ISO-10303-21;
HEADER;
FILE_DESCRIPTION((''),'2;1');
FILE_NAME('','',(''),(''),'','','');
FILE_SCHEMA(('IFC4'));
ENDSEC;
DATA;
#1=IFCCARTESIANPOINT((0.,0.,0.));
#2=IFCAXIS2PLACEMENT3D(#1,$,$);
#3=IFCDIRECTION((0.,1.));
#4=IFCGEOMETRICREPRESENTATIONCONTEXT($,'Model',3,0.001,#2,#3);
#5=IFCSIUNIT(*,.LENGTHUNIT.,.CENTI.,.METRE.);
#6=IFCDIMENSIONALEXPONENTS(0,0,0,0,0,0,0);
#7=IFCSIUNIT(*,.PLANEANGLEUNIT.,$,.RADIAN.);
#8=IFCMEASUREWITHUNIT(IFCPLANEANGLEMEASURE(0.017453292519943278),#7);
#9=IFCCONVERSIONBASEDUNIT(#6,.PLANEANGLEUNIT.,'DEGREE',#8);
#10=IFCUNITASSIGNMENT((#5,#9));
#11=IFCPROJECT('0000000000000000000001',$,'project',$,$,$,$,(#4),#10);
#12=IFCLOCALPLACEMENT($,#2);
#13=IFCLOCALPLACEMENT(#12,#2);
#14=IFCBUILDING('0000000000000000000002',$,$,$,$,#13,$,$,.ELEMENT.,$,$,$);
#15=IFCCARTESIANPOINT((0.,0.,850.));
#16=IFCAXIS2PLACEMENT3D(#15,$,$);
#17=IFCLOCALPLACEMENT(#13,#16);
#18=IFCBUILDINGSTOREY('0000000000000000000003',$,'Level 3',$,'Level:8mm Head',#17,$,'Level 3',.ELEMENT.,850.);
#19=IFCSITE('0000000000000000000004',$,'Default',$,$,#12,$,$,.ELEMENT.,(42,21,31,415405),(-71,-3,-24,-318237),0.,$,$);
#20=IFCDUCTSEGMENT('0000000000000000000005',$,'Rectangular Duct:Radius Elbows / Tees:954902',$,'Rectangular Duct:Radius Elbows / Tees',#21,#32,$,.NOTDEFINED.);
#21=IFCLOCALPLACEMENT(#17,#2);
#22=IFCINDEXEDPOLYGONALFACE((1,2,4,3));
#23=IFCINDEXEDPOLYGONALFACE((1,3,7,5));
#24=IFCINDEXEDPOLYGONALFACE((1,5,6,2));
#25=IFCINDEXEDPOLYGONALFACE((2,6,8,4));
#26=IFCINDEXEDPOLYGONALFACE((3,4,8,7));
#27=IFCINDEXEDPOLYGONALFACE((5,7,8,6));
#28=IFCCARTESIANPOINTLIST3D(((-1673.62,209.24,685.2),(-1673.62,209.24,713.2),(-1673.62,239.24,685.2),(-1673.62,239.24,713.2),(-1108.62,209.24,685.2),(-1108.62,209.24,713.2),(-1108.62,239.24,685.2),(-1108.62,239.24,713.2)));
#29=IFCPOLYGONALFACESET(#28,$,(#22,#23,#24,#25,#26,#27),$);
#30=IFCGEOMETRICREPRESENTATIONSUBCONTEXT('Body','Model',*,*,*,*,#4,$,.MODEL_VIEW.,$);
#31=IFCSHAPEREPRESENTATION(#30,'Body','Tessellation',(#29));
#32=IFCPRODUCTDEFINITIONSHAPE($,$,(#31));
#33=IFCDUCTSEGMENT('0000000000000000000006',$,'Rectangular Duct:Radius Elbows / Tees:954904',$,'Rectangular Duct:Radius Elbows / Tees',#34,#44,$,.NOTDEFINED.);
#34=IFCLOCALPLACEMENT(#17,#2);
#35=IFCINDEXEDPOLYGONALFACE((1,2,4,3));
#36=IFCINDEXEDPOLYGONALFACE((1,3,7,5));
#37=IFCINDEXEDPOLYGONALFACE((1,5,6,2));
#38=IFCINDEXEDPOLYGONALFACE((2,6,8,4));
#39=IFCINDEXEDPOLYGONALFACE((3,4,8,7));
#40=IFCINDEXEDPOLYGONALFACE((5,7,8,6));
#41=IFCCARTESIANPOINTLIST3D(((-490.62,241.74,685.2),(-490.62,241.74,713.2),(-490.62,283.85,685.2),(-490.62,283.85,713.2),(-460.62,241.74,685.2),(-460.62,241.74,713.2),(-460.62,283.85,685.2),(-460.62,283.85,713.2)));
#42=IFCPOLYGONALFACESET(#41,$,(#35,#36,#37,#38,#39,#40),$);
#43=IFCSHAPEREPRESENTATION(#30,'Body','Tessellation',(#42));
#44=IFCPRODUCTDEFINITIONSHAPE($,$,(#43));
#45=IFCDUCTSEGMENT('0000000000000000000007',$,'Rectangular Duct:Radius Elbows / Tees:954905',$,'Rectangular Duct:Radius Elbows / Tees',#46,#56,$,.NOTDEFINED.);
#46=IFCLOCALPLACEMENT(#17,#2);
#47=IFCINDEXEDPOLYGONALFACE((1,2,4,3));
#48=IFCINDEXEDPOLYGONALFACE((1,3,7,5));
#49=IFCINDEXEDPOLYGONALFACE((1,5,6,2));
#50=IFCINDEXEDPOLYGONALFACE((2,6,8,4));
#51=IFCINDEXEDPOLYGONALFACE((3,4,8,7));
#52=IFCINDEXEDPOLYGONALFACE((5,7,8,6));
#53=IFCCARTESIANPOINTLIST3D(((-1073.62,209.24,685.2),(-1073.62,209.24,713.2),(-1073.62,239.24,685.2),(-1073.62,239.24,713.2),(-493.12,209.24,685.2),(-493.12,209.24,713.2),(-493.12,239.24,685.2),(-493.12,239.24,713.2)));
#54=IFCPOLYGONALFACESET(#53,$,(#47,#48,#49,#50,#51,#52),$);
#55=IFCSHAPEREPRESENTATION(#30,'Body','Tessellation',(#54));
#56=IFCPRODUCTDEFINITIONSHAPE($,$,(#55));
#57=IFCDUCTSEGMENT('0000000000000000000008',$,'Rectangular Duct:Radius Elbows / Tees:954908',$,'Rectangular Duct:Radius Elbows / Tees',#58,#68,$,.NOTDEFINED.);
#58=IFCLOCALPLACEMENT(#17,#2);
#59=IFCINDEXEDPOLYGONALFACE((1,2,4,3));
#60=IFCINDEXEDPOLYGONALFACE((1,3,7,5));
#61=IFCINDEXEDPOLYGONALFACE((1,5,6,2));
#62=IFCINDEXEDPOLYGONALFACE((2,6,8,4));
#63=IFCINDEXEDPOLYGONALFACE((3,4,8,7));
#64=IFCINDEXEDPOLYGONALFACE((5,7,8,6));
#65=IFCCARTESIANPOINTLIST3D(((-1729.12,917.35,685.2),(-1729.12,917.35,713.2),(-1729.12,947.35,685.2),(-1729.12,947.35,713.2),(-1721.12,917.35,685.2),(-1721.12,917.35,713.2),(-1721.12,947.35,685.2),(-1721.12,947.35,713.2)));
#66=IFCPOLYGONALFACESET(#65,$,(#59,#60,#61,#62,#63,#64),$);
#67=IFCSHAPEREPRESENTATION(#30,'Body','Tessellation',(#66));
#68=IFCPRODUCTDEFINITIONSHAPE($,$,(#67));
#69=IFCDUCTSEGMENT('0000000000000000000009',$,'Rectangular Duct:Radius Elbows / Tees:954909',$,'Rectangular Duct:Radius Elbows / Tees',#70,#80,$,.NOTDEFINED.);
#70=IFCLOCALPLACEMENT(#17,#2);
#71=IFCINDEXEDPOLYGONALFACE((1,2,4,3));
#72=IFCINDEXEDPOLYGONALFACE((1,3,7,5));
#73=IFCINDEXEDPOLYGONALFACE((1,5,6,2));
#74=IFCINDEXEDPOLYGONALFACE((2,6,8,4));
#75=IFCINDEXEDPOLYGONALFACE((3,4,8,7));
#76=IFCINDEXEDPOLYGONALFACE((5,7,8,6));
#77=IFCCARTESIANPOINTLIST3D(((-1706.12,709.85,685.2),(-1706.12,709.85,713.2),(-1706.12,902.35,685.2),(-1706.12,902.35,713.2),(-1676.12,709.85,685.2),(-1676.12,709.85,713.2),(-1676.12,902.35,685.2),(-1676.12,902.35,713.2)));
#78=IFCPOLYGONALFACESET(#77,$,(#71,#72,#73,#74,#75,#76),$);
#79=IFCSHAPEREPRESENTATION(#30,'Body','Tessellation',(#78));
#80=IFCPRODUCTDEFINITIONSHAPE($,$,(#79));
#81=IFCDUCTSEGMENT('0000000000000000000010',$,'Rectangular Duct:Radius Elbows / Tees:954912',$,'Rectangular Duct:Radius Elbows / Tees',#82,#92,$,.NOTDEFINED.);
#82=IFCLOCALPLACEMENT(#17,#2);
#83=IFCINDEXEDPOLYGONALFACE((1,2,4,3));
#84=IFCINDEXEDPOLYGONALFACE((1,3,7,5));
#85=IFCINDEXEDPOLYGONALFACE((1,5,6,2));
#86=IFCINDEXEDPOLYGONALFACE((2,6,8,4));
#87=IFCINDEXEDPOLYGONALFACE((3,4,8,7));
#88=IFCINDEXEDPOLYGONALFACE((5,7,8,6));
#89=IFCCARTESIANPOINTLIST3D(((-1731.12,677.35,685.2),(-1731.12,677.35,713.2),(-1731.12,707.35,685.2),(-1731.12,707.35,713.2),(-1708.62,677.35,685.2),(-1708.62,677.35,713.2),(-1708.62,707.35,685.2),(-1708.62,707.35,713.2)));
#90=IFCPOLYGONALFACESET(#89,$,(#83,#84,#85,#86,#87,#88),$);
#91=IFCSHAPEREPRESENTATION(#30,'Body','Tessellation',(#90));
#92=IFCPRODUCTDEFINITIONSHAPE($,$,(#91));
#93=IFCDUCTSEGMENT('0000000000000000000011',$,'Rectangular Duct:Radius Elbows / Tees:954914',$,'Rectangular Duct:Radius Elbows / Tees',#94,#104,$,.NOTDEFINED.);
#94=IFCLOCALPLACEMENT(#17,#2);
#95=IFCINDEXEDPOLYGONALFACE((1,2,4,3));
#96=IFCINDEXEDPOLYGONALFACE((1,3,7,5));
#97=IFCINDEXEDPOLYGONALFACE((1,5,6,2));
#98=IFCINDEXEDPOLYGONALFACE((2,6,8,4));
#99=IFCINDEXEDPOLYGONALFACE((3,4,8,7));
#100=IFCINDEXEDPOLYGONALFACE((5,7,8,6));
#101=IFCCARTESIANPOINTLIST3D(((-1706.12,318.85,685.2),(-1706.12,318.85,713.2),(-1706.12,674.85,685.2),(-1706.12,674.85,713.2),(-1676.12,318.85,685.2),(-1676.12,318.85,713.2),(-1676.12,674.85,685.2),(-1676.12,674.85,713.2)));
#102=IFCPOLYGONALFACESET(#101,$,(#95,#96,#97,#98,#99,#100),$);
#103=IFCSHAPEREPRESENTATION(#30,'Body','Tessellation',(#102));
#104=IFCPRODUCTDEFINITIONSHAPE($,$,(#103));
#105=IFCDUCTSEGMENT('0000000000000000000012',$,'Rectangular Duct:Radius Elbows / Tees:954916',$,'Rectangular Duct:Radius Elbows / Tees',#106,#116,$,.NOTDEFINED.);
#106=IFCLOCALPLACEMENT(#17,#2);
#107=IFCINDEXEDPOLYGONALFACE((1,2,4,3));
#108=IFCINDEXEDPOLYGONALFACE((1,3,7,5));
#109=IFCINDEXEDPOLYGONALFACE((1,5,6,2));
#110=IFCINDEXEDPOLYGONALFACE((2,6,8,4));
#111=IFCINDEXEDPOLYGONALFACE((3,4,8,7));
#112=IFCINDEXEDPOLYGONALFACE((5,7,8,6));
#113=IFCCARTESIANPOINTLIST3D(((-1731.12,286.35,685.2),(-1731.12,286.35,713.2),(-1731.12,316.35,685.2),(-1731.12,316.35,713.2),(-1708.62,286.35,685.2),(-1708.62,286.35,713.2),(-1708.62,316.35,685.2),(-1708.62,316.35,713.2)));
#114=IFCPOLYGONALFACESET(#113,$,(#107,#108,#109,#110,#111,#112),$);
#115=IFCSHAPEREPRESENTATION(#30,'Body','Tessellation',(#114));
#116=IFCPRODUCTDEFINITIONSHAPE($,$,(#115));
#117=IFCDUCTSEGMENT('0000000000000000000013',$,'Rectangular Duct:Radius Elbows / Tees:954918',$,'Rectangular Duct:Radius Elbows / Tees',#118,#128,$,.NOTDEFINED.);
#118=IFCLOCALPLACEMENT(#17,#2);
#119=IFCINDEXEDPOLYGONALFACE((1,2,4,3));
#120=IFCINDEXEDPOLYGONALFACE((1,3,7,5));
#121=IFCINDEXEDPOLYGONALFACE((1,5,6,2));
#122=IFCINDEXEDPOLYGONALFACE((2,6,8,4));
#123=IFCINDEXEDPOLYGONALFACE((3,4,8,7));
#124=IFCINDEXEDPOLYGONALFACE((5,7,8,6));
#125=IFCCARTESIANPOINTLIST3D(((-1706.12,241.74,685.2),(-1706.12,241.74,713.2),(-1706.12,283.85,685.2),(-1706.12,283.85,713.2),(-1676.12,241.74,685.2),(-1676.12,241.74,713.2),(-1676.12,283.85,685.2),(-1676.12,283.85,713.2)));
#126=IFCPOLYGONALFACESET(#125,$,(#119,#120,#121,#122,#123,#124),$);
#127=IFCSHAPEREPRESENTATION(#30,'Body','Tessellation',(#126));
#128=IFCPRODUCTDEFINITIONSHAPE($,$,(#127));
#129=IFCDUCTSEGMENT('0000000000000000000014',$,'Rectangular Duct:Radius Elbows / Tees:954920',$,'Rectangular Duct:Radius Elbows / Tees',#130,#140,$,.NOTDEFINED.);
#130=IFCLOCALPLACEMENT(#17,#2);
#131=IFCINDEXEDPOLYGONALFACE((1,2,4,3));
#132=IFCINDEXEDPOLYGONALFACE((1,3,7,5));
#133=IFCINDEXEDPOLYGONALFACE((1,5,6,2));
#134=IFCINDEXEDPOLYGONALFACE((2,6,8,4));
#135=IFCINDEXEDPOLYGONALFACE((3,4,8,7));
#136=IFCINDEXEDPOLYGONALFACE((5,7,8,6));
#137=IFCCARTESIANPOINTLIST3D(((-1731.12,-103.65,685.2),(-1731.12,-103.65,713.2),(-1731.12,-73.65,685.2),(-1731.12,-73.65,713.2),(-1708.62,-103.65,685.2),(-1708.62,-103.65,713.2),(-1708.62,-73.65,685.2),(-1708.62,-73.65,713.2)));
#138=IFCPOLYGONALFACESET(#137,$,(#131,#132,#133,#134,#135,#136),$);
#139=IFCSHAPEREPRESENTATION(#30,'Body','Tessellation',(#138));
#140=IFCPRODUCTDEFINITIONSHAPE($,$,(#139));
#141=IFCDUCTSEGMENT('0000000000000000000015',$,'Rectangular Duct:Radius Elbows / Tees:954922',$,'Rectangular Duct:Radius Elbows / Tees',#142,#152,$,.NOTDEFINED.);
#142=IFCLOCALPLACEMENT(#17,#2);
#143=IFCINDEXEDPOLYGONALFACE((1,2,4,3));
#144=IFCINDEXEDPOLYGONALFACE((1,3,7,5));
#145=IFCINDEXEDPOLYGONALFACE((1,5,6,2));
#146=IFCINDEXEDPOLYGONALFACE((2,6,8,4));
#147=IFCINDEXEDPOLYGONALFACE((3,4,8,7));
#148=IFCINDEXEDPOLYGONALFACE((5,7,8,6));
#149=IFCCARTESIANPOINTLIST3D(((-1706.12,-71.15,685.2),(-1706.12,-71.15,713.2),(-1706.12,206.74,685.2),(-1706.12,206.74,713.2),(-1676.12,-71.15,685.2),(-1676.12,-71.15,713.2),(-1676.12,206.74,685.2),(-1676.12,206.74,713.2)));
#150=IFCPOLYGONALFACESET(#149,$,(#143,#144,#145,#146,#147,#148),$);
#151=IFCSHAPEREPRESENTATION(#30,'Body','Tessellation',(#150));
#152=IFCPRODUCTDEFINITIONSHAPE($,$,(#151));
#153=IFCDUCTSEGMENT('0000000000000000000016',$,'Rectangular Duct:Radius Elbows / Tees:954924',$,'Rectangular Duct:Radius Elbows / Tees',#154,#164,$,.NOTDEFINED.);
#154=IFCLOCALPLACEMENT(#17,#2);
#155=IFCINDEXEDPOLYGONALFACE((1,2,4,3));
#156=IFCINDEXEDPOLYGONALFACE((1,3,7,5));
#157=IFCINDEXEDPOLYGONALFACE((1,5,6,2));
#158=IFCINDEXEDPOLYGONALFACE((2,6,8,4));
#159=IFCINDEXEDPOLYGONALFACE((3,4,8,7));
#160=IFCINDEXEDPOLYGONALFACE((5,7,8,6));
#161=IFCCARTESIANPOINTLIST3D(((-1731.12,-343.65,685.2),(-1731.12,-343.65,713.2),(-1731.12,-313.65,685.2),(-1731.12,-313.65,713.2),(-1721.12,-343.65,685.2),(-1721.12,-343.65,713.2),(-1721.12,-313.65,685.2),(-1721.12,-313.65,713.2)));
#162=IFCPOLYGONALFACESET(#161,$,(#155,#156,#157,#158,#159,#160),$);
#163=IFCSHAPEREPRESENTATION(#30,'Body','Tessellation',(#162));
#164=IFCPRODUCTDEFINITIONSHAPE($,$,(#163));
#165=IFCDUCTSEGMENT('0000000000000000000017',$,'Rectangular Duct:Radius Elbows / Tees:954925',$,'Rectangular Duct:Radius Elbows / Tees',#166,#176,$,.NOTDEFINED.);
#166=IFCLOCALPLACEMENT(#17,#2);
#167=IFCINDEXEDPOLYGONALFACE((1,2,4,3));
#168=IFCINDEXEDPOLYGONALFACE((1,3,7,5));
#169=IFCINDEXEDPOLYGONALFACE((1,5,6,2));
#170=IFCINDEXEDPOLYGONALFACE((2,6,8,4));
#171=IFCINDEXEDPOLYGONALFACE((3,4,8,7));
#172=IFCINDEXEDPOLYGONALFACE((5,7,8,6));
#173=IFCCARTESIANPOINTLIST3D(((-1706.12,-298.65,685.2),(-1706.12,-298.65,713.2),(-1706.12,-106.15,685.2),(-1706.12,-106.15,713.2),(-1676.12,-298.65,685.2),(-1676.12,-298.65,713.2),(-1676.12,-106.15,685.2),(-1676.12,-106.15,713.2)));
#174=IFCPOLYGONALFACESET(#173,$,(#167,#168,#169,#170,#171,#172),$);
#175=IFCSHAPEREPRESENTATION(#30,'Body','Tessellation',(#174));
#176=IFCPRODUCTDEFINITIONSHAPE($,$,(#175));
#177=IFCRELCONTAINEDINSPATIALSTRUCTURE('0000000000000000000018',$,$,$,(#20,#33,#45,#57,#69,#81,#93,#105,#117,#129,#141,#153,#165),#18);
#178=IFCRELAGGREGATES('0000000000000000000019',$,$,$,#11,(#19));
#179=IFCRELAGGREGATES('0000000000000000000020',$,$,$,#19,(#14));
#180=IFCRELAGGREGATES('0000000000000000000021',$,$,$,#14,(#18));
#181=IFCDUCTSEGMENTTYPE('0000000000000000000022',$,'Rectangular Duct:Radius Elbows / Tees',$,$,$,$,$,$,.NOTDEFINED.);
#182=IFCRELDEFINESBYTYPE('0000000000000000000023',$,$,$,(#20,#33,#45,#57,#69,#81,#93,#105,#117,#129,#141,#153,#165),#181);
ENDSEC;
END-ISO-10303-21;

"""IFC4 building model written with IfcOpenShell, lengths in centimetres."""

from ifc_helpers import new_model, entity, si_unit, converted_unit, direction, frame, origin, place, context, subcontext, project, spatial, indexed_curve, outline, extrude, type_object, element, save


model = new_model("IFC4")

# Units and contexts
model_context = context("Model", 3, precision=0.001, world=origin(), true_north=direction((0.0, 1.0)))
body_context = subcontext(model_context, "Body", "Model", "MODEL_VIEW")
ifc_project = project(units=[si_unit("LENGTHUNIT", "METRE", prefix="CENTI"), converted_unit("PLANEANGLEUNIT", "DEGREE", entity("IfcPlaneAngleMeasure", 0.017453292519943278), si_unit("PLANEANGLEUNIT", "RADIAN"), dimensions=[0, 0, 0, 0, 0, 0, 0])], contexts=[model_context])

# Site, building, storey
site_placement = place(None, origin())
site = spatial("IfcSite", under=ifc_project, at=site_placement, Name="Default", CompositionType="ELEMENT", RefLatitude=(42, 21, 31, 415405), RefLongitude=(-71, -3, -24, -318237), RefElevation=0.0)
building_placement = place(site_placement, origin())
building = spatial("IfcBuilding", under=site, at=building_placement, CompositionType="ELEMENT")
storey_placement = place(building_placement, frame((0.0, 0.0, 850.0)))
storey = spatial("IfcBuildingStorey", under=building, at=storey_placement, Name="Level 3", ObjectType="Level:8mm Head", LongName="Level 3", CompositionType="ELEMENT", Elevation=850.0)

# Duct segments
duct_segment_type = type_object("IfcDuctSegmentType", Name="Rectangular Duct:Radius Elbows / Tees", PredefinedType="NOTDEFINED")
duct_segment_1_placement = place(storey_placement, origin())
element("IfcDuctSegment", 1, at=duct_segment_1_placement, inside=storey, type_object=duct_segment_type, Name="Rectangular Duct:Radius Elbows / Tees:954902", ObjectType="Rectangular Duct:Radius Elbows / Tees", PredefinedType="NOTDEFINED", context=body_context, shape_type="SweptSolid", body=[
    extrude(outline(indexed_curve([(-282.5, -15.0), (282.5, -15.0), (282.5, 15.0), (-282.5, 15.0), (-282.5, -15.0)], self_intersect=False)), frame((-1391.12, 224.24, 685.2), z_axis=(0.0, 0.0, 1.0), x_axis=(-1.0, 0.0, 0.0)), (0.0, 0.0, 1.0), 28.0),
])
duct_segment_2_placement = place(storey_placement, origin())
element("IfcDuctSegment", 2, at=duct_segment_2_placement, inside=storey, type_object=duct_segment_type, Name="Rectangular Duct:Radius Elbows / Tees:954904", ObjectType="Rectangular Duct:Radius Elbows / Tees", PredefinedType="NOTDEFINED", context=body_context, shape_type="SweptSolid", body=[
    extrude(outline(indexed_curve([(-21.05, -15.0), (21.05, -15.0), (21.05, 15.0), (-21.05, 15.0), (-21.05, -15.0)], self_intersect=False)), frame((-475.62, 262.79, 685.2), z_axis=(0.0, 0.0, 1.0), x_axis=(0.0, -1.0, 0.0)), (0.0, 0.0, 1.0), 28.0),
])
duct_segment_3_placement = place(storey_placement, origin())
element("IfcDuctSegment", 3, at=duct_segment_3_placement, inside=storey, type_object=duct_segment_type, Name="Rectangular Duct:Radius Elbows / Tees:954905", ObjectType="Rectangular Duct:Radius Elbows / Tees", PredefinedType="NOTDEFINED", context=body_context, shape_type="SweptSolid", body=[
    extrude(outline(indexed_curve([(-290.25, -15.0), (290.25, -15.0), (290.25, 15.0), (-290.25, 15.0), (-290.25, -15.0)], self_intersect=False)), frame((-783.37, 224.24, 685.2), z_axis=(0.0, 0.0, 1.0), x_axis=(-1.0, 0.0, 0.0)), (0.0, 0.0, 1.0), 28.0),
])
duct_segment_4_placement = place(storey_placement, origin())
element("IfcDuctSegment", 4, at=duct_segment_4_placement, inside=storey, type_object=duct_segment_type, Name="Rectangular Duct:Radius Elbows / Tees:954908", ObjectType="Rectangular Duct:Radius Elbows / Tees", PredefinedType="NOTDEFINED", context=body_context, shape_type="SweptSolid", body=[
    extrude(outline(indexed_curve([(-4.0, -15.0), (4.0, -15.0), (4.0, 15.0), (-4.0, 15.0), (-4.0, -15.0)], self_intersect=False)), frame((-1725.12, 932.35, 685.2), z_axis=(0.0, 0.0, 1.0), x_axis=(-1.0, 0.0, 0.0)), (0.0, 0.0, 1.0), 28.0),
])
duct_segment_5_placement = place(storey_placement, origin())
element("IfcDuctSegment", 5, at=duct_segment_5_placement, inside=storey, type_object=duct_segment_type, Name="Rectangular Duct:Radius Elbows / Tees:954909", ObjectType="Rectangular Duct:Radius Elbows / Tees", PredefinedType="NOTDEFINED", context=body_context, shape_type="SweptSolid", body=[
    extrude(outline(indexed_curve([(-96.25, -15.0), (96.25, -15.0), (96.25, 15.0), (-96.25, 15.0), (-96.25, -15.0)], self_intersect=False)), frame((-1691.12, 806.1, 685.2), z_axis=(0.0, 0.0, 1.0), x_axis=(0.0, 1.0, 0.0)), (0.0, 0.0, 1.0), 28.0),
])
duct_segment_6_placement = place(storey_placement, origin())
element("IfcDuctSegment", 6, at=duct_segment_6_placement, inside=storey, type_object=duct_segment_type, Name="Rectangular Duct:Radius Elbows / Tees:954912", ObjectType="Rectangular Duct:Radius Elbows / Tees", PredefinedType="NOTDEFINED", context=body_context, shape_type="SweptSolid", body=[
    extrude(outline(indexed_curve([(-11.25, -15.0), (11.25, -15.0), (11.25, 15.0), (-11.25, 15.0), (-11.25, -15.0)], self_intersect=False)), frame((-1719.87, 692.35, 685.2), z_axis=(0.0, 0.0, 1.0), x_axis=(-1.0, 0.0, 0.0)), (0.0, 0.0, 1.0), 28.0),
])
duct_segment_7_placement = place(storey_placement, origin())
element("IfcDuctSegment", 7, at=duct_segment_7_placement, inside=storey, type_object=duct_segment_type, Name="Rectangular Duct:Radius Elbows / Tees:954914", ObjectType="Rectangular Duct:Radius Elbows / Tees", PredefinedType="NOTDEFINED", context=body_context, shape_type="SweptSolid", body=[
    extrude(outline(indexed_curve([(-178.0, -15.0), (178.0, -15.0), (178.0, 15.0), (-178.0, 15.0), (-178.0, -15.0)], self_intersect=False)), frame((-1691.12, 496.85, 685.2), z_axis=(0.0, 0.0, 1.0), x_axis=(0.0, 1.0, 0.0)), (0.0, 0.0, 1.0), 28.0),
])
duct_segment_8_placement = place(storey_placement, origin())
element("IfcDuctSegment", 8, at=duct_segment_8_placement, inside=storey, type_object=duct_segment_type, Name="Rectangular Duct:Radius Elbows / Tees:954916", ObjectType="Rectangular Duct:Radius Elbows / Tees", PredefinedType="NOTDEFINED", context=body_context, shape_type="SweptSolid", body=[
    extrude(outline(indexed_curve([(-11.25, -15.0), (11.25, -15.0), (11.25, 15.0), (-11.25, 15.0), (-11.25, -15.0)], self_intersect=False)), frame((-1719.87, 301.35, 685.2), z_axis=(0.0, 0.0, 1.0), x_axis=(-1.0, 0.0, 0.0)), (0.0, 0.0, 1.0), 28.0),
])
duct_segment_9_placement = place(storey_placement, origin())
element("IfcDuctSegment", 9, at=duct_segment_9_placement, inside=storey, type_object=duct_segment_type, Name="Rectangular Duct:Radius Elbows / Tees:954918", ObjectType="Rectangular Duct:Radius Elbows / Tees", PredefinedType="NOTDEFINED", context=body_context, shape_type="SweptSolid", body=[
    extrude(outline(indexed_curve([(-21.05, -15.0), (21.05, -15.0), (21.05, 15.0), (-21.05, 15.0), (-21.05, -15.0)], self_intersect=False)), frame((-1691.12, 262.79, 685.2), z_axis=(0.0, 0.0, 1.0), x_axis=(0.0, 1.0, 0.0)), (0.0, 0.0, 1.0), 28.0),
])
duct_segment_10_placement = place(storey_placement, origin())
element("IfcDuctSegment", 10, at=duct_segment_10_placement, inside=storey, type_object=duct_segment_type, Name="Rectangular Duct:Radius Elbows / Tees:954920", ObjectType="Rectangular Duct:Radius Elbows / Tees", PredefinedType="NOTDEFINED", context=body_context, shape_type="SweptSolid", body=[
    extrude(outline(indexed_curve([(-11.25, -15.0), (11.25, -15.0), (11.25, 15.0), (-11.25, 15.0), (-11.25, -15.0)], self_intersect=False)), frame((-1719.87, -88.65, 685.2), z_axis=(0.0, 0.0, 1.0), x_axis=(-1.0, 0.0, 0.0)), (0.0, 0.0, 1.0), 28.0),
])
duct_segment_11_placement = place(storey_placement, origin())
element("IfcDuctSegment", 11, at=duct_segment_11_placement, inside=storey, type_object=duct_segment_type, Name="Rectangular Duct:Radius Elbows / Tees:954922", ObjectType="Rectangular Duct:Radius Elbows / Tees", PredefinedType="NOTDEFINED", context=body_context, shape_type="SweptSolid", body=[
    extrude(outline(indexed_curve([(-138.95, -15.0), (138.95, -15.0), (138.95, 15.0), (-138.95, 15.0), (-138.95, -15.0)], self_intersect=False)), frame((-1691.12, 67.79, 685.2), z_axis=(0.0, 0.0, 1.0), x_axis=(0.0, -1.0, 0.0)), (0.0, 0.0, 1.0), 28.0),
])
duct_segment_12_placement = place(storey_placement, origin())
element("IfcDuctSegment", 12, at=duct_segment_12_placement, inside=storey, type_object=duct_segment_type, Name="Rectangular Duct:Radius Elbows / Tees:954924", ObjectType="Rectangular Duct:Radius Elbows / Tees", PredefinedType="NOTDEFINED", context=body_context, shape_type="SweptSolid", body=[
    extrude(outline(indexed_curve([(-5.0, -15.0), (5.0, -15.0), (5.0, 15.0), (-5.0, 15.0), (-5.0, -15.0)], self_intersect=False)), frame((-1726.12, -328.65, 685.2), z_axis=(0.0, 0.0, 1.0), x_axis=(-1.0, 0.0, 0.0)), (0.0, 0.0, 1.0), 28.0),
])
duct_segment_13_placement = place(storey_placement, origin())
element("IfcDuctSegment", 13, at=duct_segment_13_placement, inside=storey, type_object=duct_segment_type, Name="Rectangular Duct:Radius Elbows / Tees:954925", ObjectType="Rectangular Duct:Radius Elbows / Tees", PredefinedType="NOTDEFINED", context=body_context, shape_type="SweptSolid", body=[
    extrude(outline(indexed_curve([(-96.25, -15.0), (96.25, -15.0), (96.25, 15.0), (-96.25, 15.0), (-96.25, -15.0)], self_intersect=False)), frame((-1691.12, -202.4, 685.2), z_axis=(0.0, 0.0, 1.0), x_axis=(0.0, -1.0, 0.0)), (0.0, 0.0, 1.0), 28.0),
])

save(model, "model.ifc")
